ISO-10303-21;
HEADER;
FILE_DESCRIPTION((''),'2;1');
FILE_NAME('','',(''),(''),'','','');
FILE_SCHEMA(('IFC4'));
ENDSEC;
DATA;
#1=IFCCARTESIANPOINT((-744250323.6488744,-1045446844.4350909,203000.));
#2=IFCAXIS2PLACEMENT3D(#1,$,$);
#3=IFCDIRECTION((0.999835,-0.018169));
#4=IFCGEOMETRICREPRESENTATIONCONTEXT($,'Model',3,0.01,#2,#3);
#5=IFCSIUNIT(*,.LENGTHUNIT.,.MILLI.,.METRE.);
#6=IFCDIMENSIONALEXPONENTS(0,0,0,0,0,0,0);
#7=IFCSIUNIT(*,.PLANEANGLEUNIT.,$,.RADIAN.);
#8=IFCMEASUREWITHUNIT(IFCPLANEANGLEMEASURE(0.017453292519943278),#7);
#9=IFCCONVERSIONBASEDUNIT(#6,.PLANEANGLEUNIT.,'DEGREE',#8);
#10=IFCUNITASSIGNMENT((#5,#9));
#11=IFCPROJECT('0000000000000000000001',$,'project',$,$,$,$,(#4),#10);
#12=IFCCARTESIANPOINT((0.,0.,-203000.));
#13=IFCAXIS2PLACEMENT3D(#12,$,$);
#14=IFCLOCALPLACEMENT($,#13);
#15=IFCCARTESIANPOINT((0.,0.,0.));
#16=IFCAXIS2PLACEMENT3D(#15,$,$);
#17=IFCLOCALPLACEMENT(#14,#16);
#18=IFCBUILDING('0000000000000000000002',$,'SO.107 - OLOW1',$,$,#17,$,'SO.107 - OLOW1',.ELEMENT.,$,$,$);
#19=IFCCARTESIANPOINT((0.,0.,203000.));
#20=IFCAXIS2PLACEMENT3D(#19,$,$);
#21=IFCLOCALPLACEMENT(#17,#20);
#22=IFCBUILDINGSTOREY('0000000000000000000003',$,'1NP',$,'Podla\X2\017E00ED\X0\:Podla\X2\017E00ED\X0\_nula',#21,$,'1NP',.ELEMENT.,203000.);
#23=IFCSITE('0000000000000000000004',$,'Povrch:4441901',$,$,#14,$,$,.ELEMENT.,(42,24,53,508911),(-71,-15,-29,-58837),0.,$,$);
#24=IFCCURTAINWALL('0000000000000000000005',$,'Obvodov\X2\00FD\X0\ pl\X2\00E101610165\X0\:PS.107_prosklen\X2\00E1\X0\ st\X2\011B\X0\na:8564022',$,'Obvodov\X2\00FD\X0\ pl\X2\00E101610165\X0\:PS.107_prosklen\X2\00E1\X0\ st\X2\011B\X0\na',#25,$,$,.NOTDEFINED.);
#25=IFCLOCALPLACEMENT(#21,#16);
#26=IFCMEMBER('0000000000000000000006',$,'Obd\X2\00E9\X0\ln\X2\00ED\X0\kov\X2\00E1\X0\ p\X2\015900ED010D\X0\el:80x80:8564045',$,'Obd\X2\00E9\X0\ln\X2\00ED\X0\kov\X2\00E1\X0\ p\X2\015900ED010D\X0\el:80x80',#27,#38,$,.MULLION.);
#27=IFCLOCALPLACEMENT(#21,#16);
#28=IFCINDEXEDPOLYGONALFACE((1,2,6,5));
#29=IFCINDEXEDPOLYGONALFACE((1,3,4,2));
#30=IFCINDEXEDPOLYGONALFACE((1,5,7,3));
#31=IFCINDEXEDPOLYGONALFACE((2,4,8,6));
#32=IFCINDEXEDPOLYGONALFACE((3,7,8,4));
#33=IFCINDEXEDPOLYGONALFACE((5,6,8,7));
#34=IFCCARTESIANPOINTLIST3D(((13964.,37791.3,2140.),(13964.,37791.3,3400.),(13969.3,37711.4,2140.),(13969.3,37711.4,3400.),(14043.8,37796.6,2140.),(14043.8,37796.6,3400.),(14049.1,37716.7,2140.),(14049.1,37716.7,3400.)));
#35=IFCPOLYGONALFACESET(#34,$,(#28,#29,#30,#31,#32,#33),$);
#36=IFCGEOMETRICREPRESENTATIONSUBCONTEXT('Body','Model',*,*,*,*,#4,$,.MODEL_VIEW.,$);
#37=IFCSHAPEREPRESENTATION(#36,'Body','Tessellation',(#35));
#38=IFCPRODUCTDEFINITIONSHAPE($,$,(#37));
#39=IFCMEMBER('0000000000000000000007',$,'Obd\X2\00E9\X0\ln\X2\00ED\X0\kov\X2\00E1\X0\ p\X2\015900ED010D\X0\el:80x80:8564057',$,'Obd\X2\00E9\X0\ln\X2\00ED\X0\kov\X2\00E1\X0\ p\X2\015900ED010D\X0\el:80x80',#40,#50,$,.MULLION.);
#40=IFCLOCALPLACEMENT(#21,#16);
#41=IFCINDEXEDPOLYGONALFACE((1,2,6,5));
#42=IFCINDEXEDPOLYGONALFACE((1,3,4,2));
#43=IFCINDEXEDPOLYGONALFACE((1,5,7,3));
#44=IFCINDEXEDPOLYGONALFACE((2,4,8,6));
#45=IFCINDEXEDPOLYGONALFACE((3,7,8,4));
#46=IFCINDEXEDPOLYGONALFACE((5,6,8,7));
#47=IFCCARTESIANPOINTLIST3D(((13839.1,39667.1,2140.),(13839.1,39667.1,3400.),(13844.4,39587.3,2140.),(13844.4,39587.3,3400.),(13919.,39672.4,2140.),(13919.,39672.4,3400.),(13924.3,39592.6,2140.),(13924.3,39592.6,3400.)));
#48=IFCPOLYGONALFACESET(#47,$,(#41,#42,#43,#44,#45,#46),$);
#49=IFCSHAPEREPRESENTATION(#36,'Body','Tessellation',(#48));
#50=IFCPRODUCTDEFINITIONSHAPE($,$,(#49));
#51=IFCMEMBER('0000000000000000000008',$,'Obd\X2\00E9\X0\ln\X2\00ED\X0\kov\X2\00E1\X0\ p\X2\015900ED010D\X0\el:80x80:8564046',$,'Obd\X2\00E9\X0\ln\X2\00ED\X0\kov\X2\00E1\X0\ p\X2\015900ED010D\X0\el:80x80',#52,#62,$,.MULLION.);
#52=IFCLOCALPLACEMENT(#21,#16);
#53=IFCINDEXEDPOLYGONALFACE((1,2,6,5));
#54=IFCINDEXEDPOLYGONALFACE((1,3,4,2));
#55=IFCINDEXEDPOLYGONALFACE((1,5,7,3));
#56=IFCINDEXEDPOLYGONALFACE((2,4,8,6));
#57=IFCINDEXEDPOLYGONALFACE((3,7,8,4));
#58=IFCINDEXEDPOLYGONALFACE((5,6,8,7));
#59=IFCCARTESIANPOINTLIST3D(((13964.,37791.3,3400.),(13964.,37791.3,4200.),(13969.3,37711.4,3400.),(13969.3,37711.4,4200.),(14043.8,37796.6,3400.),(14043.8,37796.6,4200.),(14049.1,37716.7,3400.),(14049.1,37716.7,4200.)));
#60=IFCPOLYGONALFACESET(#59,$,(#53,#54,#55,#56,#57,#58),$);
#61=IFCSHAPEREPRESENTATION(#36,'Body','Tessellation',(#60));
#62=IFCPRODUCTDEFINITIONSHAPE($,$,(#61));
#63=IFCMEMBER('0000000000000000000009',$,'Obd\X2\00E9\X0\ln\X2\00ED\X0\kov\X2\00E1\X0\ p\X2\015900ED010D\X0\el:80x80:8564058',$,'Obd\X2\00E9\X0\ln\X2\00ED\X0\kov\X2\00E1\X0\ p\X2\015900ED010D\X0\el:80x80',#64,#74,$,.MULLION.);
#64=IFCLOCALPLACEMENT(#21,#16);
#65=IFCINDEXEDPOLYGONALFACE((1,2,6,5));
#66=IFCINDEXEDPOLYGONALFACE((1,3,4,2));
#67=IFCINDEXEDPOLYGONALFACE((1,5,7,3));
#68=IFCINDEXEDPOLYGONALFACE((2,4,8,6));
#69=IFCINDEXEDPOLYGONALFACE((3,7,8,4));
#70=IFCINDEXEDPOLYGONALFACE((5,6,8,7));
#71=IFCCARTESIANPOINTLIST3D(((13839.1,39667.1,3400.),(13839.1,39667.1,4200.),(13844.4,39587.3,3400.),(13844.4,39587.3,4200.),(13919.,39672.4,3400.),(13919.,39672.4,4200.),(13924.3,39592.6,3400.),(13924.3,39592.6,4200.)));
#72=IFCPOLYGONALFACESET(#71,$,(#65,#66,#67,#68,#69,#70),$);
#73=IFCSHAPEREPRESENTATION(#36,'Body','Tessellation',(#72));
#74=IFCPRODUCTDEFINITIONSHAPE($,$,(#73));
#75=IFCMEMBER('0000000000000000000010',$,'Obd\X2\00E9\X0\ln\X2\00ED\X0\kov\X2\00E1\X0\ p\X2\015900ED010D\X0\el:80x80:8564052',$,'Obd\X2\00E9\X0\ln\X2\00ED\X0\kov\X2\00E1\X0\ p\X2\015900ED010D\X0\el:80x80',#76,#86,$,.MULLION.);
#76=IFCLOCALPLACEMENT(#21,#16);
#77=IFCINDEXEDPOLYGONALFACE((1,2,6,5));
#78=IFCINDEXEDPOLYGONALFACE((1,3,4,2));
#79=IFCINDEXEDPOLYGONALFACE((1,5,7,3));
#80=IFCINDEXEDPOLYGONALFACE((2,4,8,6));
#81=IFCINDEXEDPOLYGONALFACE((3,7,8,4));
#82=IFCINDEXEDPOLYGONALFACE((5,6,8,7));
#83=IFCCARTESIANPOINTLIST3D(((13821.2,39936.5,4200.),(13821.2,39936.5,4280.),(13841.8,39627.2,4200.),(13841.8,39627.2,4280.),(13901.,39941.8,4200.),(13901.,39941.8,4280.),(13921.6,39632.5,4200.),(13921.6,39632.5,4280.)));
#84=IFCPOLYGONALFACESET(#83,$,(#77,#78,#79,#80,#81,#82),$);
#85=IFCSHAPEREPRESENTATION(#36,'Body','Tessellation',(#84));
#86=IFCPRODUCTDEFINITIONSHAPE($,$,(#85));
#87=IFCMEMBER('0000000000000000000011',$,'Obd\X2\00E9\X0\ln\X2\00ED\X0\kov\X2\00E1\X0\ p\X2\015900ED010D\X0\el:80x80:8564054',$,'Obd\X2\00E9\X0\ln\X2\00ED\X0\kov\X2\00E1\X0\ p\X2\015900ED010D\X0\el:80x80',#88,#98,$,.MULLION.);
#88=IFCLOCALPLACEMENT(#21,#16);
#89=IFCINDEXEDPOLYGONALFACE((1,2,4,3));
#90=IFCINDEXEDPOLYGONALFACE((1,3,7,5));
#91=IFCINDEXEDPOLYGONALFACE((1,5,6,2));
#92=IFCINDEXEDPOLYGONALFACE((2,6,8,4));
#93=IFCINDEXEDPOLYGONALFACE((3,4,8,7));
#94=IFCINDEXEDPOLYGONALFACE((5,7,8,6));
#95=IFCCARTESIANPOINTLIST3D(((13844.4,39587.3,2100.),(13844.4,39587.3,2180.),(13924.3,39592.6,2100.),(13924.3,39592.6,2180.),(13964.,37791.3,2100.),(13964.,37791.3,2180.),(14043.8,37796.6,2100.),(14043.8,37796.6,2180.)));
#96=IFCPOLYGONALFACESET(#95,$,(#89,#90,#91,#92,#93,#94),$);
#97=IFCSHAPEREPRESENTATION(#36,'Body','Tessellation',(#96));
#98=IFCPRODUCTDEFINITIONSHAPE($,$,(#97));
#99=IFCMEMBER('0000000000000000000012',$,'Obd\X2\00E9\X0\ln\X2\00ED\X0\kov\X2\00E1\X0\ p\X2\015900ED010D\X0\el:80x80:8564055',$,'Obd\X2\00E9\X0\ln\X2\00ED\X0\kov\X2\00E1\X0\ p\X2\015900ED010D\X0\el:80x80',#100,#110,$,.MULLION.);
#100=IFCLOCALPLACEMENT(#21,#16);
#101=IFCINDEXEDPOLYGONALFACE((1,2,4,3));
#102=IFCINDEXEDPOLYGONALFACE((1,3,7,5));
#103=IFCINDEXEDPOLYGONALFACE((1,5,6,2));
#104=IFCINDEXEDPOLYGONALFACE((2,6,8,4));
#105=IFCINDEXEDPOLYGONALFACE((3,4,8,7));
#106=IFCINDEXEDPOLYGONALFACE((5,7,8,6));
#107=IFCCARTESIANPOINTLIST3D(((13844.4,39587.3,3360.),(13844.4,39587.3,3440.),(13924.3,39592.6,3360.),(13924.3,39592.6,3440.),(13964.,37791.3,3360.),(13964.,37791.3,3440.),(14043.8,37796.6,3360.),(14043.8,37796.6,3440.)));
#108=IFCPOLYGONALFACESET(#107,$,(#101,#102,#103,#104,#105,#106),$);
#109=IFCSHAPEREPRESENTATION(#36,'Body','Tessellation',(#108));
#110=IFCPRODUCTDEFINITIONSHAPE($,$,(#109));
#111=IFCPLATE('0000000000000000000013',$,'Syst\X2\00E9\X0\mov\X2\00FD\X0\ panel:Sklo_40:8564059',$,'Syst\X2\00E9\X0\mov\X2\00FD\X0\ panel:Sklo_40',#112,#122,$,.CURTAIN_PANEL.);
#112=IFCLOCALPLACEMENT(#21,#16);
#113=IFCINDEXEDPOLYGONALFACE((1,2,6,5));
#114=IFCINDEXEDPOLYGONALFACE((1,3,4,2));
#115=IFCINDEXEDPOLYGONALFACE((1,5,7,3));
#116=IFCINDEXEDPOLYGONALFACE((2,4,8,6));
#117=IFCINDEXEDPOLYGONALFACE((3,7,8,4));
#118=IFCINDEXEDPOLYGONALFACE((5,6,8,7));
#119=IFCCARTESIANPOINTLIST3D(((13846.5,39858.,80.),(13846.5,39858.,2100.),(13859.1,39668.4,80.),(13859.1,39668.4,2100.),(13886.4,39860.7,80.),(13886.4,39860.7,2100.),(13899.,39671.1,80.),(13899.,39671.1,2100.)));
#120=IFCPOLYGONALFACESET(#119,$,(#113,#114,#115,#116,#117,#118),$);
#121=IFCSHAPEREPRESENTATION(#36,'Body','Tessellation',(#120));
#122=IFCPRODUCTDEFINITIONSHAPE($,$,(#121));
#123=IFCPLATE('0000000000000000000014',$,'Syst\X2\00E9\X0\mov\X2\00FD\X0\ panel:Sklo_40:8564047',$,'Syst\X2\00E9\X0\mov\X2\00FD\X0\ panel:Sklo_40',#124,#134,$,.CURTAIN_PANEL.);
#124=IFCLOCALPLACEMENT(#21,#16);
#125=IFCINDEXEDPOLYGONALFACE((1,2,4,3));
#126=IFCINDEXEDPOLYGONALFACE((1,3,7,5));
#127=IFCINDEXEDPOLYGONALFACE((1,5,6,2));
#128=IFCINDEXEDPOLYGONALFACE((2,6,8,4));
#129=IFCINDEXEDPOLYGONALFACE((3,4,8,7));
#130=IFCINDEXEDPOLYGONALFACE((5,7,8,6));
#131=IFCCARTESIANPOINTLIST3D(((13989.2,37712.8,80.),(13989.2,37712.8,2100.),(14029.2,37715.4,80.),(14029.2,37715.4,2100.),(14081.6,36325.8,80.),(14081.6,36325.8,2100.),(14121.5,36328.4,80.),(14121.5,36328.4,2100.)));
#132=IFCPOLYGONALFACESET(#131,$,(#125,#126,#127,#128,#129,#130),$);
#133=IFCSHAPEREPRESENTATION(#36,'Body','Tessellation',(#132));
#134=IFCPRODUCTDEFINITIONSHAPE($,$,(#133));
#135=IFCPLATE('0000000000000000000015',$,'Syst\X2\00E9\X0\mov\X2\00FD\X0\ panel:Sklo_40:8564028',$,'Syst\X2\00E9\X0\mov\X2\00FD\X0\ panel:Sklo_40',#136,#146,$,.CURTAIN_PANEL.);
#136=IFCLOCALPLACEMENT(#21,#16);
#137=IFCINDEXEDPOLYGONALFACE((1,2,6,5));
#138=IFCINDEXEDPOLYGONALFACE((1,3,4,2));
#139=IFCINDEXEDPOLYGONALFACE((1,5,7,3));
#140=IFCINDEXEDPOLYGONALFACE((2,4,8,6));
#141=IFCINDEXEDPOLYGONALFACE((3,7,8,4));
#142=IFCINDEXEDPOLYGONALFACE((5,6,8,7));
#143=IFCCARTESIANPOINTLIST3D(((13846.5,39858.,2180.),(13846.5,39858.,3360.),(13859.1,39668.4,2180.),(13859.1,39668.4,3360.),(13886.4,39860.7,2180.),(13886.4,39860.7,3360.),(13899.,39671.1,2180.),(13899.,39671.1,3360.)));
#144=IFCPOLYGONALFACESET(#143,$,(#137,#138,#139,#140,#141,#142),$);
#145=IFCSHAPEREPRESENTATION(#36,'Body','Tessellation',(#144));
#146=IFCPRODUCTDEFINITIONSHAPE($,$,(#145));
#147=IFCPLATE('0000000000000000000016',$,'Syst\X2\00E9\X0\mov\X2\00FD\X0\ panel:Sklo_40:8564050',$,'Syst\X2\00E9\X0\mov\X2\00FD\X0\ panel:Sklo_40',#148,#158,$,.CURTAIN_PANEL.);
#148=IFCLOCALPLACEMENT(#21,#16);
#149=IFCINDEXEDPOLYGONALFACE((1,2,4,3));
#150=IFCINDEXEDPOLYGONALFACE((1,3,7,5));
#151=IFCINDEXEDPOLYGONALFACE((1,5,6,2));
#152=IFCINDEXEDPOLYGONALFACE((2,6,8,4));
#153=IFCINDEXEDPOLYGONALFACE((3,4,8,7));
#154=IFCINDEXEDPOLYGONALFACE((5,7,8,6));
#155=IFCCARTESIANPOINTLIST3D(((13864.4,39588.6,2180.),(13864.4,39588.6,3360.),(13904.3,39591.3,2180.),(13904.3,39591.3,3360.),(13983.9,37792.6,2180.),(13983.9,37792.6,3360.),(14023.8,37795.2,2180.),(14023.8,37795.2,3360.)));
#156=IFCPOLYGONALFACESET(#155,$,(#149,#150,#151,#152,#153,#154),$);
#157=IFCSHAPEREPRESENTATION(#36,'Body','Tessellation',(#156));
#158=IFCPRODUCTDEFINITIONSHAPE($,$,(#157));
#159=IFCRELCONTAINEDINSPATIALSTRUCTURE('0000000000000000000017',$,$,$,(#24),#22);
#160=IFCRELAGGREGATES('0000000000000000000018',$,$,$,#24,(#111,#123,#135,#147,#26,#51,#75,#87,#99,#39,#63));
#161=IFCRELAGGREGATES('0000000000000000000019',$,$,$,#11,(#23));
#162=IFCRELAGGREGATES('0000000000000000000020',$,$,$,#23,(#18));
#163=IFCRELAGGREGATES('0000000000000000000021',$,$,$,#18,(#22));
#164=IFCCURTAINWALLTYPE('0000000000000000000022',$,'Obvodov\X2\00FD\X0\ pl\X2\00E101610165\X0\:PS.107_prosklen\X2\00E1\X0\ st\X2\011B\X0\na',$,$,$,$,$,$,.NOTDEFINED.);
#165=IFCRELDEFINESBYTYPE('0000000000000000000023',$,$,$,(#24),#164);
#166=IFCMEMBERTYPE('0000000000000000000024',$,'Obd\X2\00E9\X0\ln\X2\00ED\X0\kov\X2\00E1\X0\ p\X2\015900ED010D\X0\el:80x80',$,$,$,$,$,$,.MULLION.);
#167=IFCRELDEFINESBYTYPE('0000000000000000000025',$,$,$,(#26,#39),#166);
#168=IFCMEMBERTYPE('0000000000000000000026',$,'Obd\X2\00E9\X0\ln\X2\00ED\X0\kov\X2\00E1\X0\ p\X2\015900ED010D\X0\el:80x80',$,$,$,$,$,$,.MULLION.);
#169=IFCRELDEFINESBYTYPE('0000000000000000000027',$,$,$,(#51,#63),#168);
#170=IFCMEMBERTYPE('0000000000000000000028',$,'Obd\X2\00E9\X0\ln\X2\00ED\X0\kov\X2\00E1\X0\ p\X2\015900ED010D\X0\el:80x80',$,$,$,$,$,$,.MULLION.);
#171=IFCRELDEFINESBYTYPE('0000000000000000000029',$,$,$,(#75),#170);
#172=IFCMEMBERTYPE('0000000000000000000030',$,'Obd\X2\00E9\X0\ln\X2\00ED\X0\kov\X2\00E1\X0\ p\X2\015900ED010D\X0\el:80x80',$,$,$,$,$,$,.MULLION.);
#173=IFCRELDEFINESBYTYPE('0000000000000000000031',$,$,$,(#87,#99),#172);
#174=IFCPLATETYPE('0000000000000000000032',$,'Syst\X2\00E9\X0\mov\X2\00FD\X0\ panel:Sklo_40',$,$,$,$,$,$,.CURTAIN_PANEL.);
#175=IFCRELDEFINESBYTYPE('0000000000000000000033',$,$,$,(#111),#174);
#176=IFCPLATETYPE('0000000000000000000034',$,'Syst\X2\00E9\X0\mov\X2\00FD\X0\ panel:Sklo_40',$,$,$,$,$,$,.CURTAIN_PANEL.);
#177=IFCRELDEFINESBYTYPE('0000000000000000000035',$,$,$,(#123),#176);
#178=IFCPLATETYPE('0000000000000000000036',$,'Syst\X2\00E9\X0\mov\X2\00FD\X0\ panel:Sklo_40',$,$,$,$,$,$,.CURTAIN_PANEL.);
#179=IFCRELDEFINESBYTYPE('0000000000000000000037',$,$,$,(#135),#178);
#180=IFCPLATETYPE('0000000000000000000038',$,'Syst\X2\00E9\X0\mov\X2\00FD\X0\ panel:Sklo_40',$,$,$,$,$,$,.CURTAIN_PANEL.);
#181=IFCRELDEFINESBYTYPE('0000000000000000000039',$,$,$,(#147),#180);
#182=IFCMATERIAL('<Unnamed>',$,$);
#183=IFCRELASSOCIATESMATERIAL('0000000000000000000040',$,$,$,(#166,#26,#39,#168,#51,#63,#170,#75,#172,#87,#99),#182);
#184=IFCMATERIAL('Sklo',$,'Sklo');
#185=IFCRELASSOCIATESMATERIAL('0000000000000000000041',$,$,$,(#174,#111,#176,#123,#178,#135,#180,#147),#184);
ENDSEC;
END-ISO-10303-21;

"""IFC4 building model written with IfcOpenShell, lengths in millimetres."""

from ifc_helpers import new_model, entity, si_unit, converted_unit, direction, frame, origin, place, context, subcontext, project, spatial, indexed_curve, outline, extrude, source, transform, mapped, material, type_object, type_shapes, element, aggregate, save


model = new_model("IFC4")

# Units and contexts
model_context = context("Model", 3, precision=0.01, world=frame((-744250323.6488744, -1045446844.4350909, 203000.0)), true_north=direction((0.999835, -0.018169)))
body_context = subcontext(model_context, "Body", "Model", "MODEL_VIEW")
ifc_project = project(units=[si_unit("LENGTHUNIT", "METRE", prefix="MILLI"), converted_unit("PLANEANGLEUNIT", "DEGREE", entity("IfcPlaneAngleMeasure", 0.017453292519943278), si_unit("PLANEANGLEUNIT", "RADIAN"), dimensions=[0, 0, 0, 0, 0, 0, 0])], contexts=[model_context])

# Site, building, storey
site_placement = place(None, frame((0.0, 0.0, -203000.0)))
site = spatial("IfcSite", under=ifc_project, at=site_placement, Name="Povrch:4441901", CompositionType="ELEMENT", RefLatitude=(42, 24, 53, 508911), RefLongitude=(-71, -15, -29, -58837), RefElevation=0.0)
building_placement = place(site_placement, origin())
building = spatial("IfcBuilding", under=site, at=building_placement, Name="SO.107 - OLOW1", LongName="SO.107 - OLOW1", CompositionType="ELEMENT")
storey_placement = place(building_placement, frame((0.0, 0.0, 203000.0)))
storey = spatial("IfcBuildingStorey", under=building, at=storey_placement, Name="1NP", ObjectType="Podlaží:Podlaží_nula", LongName="1NP", CompositionType="ELEMENT", Elevation=203000.0)

# Curtain wall, members, plates
curtain_wall_type = type_object("IfcCurtainWallType", Name="Obvodový plášť:PS.107_prosklená stěna", PredefinedType="NOTDEFINED")
curtain_wall_placement = place(storey_placement, frame((0.0, 0.0, -203000.0)))
curtain_wall = element("IfcCurtainWall", 1, at=curtain_wall_placement, inside=storey, type_object=curtain_wall_type, Name="Obvodový plášť:PS.107_prosklená stěna:8564022", ObjectType="Obvodový plášť:PS.107_prosklená stěna", PredefinedType="NOTDEFINED")
ifc_material_1 = material(Name="<Unnamed>")
member_type_1 = type_object("IfcMemberType", Name="Obdélníková příčel:80x80", PredefinedType="MULLION", material=ifc_material_1)
shared_shape_1 = source(origin(), body_context, "Body", "SweptSolid", [
    extrude(outline(indexed_curve([(-40.0, -40.0), (40.0, -40.0), (40.0, 40.0), (-40.0, 40.0), (-40.0, -40.0)], self_intersect=False)), frame((0.0, 0.0, -1260.0), z_axis=(0.0, 0.0, 1.0), x_axis=(-1.0, 0.0, 0.0)), (0.0, 0.0, 1.0), 1260.0),
])
type_shapes(member_type_1, [shared_shape_1])
member_1_placement = place(curtain_wall_placement, frame((14006.5, 37754.0, 205140.0), z_axis=(0.0, 0.0, -1.0), x_axis=(0.066409, -0.997792, 0.0)))
member_1 = element("IfcMember", 2, at=member_1_placement, type_object=member_type_1, material=ifc_material_1, Name="Obdélníková příčel:80x80:8564045", ObjectType="Obdélníková příčel:80x80", PredefinedType="MULLION", context=body_context, shape_type="MappedRepresentation", body=[
    mapped(shared_shape_1, transform((0.0, 0.0, 0.0), scale=1.0)),
])
member_2_placement = place(curtain_wall_placement, frame((13881.7, 39629.8, 205140.0), z_axis=(0.0, 0.0, -1.0), x_axis=(0.066409, -0.997792, 0.0)))
member_2 = element("IfcMember", 3, at=member_2_placement, type_object=member_type_1, material=ifc_material_1, Name="Obdélníková příčel:80x80:8564057", ObjectType="Obdélníková příčel:80x80", PredefinedType="MULLION", context=body_context, shape_type="MappedRepresentation", body=[
    mapped(shared_shape_1, transform((0.0, 0.0, 0.0), scale=1.0)),
])
member_type_2 = type_object("IfcMemberType", Name="Obdélníková příčel:80x80", PredefinedType="MULLION", material=ifc_material_1)
shared_shape_2 = source(origin(), body_context, "Body", "SweptSolid", [
    extrude(outline(indexed_curve([(-40.0, -40.0), (40.0, -40.0), (40.0, 40.0), (-40.0, 40.0), (-40.0, -40.0)], self_intersect=False)), frame((0.0, 0.0, -800.0), z_axis=(0.0, 0.0, 1.0), x_axis=(-1.0, 0.0, 0.0)), (0.0, 0.0, 1.0), 800.0),
])
type_shapes(member_type_2, [shared_shape_2])
member_3_placement = place(curtain_wall_placement, frame((14006.5, 37754.0, 206400.0), z_axis=(0.0, 0.0, -1.0), x_axis=(0.066409, -0.997792, 0.0)))
member_3 = element("IfcMember", 4, at=member_3_placement, type_object=member_type_2, material=ifc_material_1, Name="Obdélníková příčel:80x80:8564046", ObjectType="Obdélníková příčel:80x80", PredefinedType="MULLION", context=body_context, shape_type="MappedRepresentation", body=[
    mapped(shared_shape_2, transform((0.0, 0.0, 0.0), scale=1.0)),
])
member_4_placement = place(curtain_wall_placement, frame((13881.7, 39629.8, 206400.0), z_axis=(0.0, 0.0, -1.0), x_axis=(0.066409, -0.997792, 0.0)))
member_4 = element("IfcMember", 5, at=member_4_placement, type_object=member_type_2, material=ifc_material_1, Name="Obdélníková příčel:80x80:8564058", ObjectType="Obdélníková příčel:80x80", PredefinedType="MULLION", context=body_context, shape_type="MappedRepresentation", body=[
    mapped(shared_shape_2, transform((0.0, 0.0, 0.0), scale=1.0)),
])
member_type_3 = type_object("IfcMemberType", Name="Obdélníková příčel:80x80", PredefinedType="MULLION", material=ifc_material_1)
shared_shape_3 = source(origin(), body_context, "Body", "SweptSolid", [
    extrude(outline(indexed_curve([(-40.0, -40.0), (40.0, -40.0), (40.0, 40.0), (-40.0, 40.0), (-40.0, -40.0)], self_intersect=False)), frame((-40.0, 0.0, -310.0), z_axis=(0.0, 0.0, 1.0), x_axis=(-1.0, 0.0, 0.0)), (0.0, 0.0, 1.0), 310.0),
])
type_shapes(member_type_3, [shared_shape_3])
member_5_placement = place(curtain_wall_placement, frame((13881.7, 39629.8, 207280.0), z_axis=(0.066409, -0.997792, 0.0), x_axis=(0.0, 0.0, 1.0)))
member_5 = element("IfcMember", 6, at=member_5_placement, type_object=member_type_3, material=ifc_material_1, Name="Obdélníková příčel:80x80:8564052", ObjectType="Obdélníková příčel:80x80", PredefinedType="MULLION", context=body_context, shape_type="MappedRepresentation", body=[
    mapped(shared_shape_3, transform((0.0, 0.0, 0.0), scale=1.0)),
])
member_type_4 = type_object("IfcMemberType", Name="Obdélníková příčel:80x80", PredefinedType="MULLION", material=ifc_material_1)
shared_shape_4 = source(origin(), body_context, "Body", "SweptSolid", [
    extrude(outline(indexed_curve([(-40.0, -40.0), (40.0, -40.0), (40.0, 40.0), (-40.0, 40.0), (-40.0, -40.0)], self_intersect=False)), frame((0.0, 0.0, -1800.0), z_axis=(0.0, 0.0, 1.0), x_axis=(-1.0, 0.0, 0.0)), (0.0, 0.0, 1.0), 1800.0),
])
type_shapes(member_type_4, [shared_shape_4])
member_6_placement = place(curtain_wall_placement, frame((14003.9, 37793.9, 205140.0), z_axis=(0.066409, -0.997792, 0.0), x_axis=(0.0, 0.0, 1.0)))
member_6 = element("IfcMember", 7, at=member_6_placement, type_object=member_type_4, material=ifc_material_1, Name="Obdélníková příčel:80x80:8564054", ObjectType="Obdélníková příčel:80x80", PredefinedType="MULLION", context=body_context, shape_type="MappedRepresentation", body=[
    mapped(shared_shape_4, transform((0.0, 0.0, 0.0), scale=1.0)),
])
member_7_placement = place(curtain_wall_placement, frame((14003.9, 37793.9, 206400.0), z_axis=(0.066409, -0.997792, 0.0), x_axis=(0.0, 0.0, 1.0)))
member_7 = element("IfcMember", 8, at=member_7_placement, type_object=member_type_4, material=ifc_material_1, Name="Obdélníková příčel:80x80:8564055", ObjectType="Obdélníková příčel:80x80", PredefinedType="MULLION", context=body_context, shape_type="MappedRepresentation", body=[
    mapped(shared_shape_4, transform((0.0, 0.0, 0.0), scale=1.0)),
])
ifc_material_2 = material(Name="Sklo", Category="Sklo")
plate_type_1 = type_object("IfcPlateType", Name="Systémový panel:Sklo_40", PredefinedType="CURTAIN_PANEL", material=ifc_material_2)
shared_shape_5 = source(origin(), body_context, "Body", "SweptSolid", [
    extrude(outline(indexed_curve([(-20.0, -95.0), (20.0, -95.0), (20.0, 95.0), (-20.0, 95.0), (-20.0, -95.0)], self_intersect=False)), frame((0.0, 0.0, 0.0), z_axis=(0.0, 0.0, 1.0), x_axis=(0.0, 1.0, 0.0)), (0.0, 0.0, 1.0), 2020.0),
])
type_shapes(plate_type_1, [shared_shape_5])
plate_1_placement = place(curtain_wall_placement, frame((13872.7, 39764.5, 203080.0), z_axis=(0.0, 0.0, 1.0), x_axis=(0.066409, -0.997792, 0.0)))
plate_1 = element("IfcPlate", 9, at=plate_1_placement, type_object=plate_type_1, material=ifc_material_2, Name="Systémový panel:Sklo_40:8564059", ObjectType="Systémový panel:Sklo_40", PredefinedType="CURTAIN_PANEL", context=body_context, shape_type="MappedRepresentation", body=[
    mapped(shared_shape_5, transform((0.0, 0.0, 0.0), scale=1.0)),
])
plate_type_2 = type_object("IfcPlateType", Name="Systémový panel:Sklo_40", PredefinedType="CURTAIN_PANEL", material=ifc_material_2)
shared_shape_6 = source(origin(), body_context, "Body", "SweptSolid", [
    extrude(outline(indexed_curve([(-20.0, -695.0), (20.0, -695.0), (20.0, 695.0), (-20.0, 695.0), (-20.0, -695.0)], self_intersect=False)), frame((0.0, 0.0, 0.0), z_axis=(0.0, 0.0, 1.0), x_axis=(0.0, 1.0, 0.0)), (0.0, 0.0, 1.0), 2020.0),
])
type_shapes(plate_type_2, [shared_shape_6])
plate_2_placement = place(curtain_wall_placement, frame((14055.4, 37020.6, 203080.0), z_axis=(0.0, 0.0, 1.0), x_axis=(0.066409, -0.997792, 0.0)))
plate_2 = element("IfcPlate", 10, at=plate_2_placement, type_object=plate_type_2, material=ifc_material_2, Name="Systémový panel:Sklo_40:8564047", ObjectType="Systémový panel:Sklo_40", PredefinedType="CURTAIN_PANEL", context=body_context, shape_type="MappedRepresentation", body=[
    mapped(shared_shape_6, transform((0.0, 0.0, 0.0), scale=1.0)),
])
plate_type_3 = type_object("IfcPlateType", Name="Systémový panel:Sklo_40", PredefinedType="CURTAIN_PANEL", material=ifc_material_2)
shared_shape_7 = source(origin(), body_context, "Body", "SweptSolid", [
    extrude(outline(indexed_curve([(-20.0, -95.0), (20.0, -95.0), (20.0, 95.0), (-20.0, 95.0), (-20.0, -95.0)], self_intersect=False)), frame((0.0, 0.0, 0.0), z_axis=(0.0, 0.0, 1.0), x_axis=(0.0, 1.0, 0.0)), (0.0, 0.0, 1.0), 1180.0),
])
type_shapes(plate_type_3, [shared_shape_7])
plate_3_placement = place(curtain_wall_placement, frame((13872.7, 39764.5, 205180.0), z_axis=(0.0, 0.0, 1.0), x_axis=(0.066409, -0.997792, 0.0)))
plate_3 = element("IfcPlate", 11, at=plate_3_placement, type_object=plate_type_3, material=ifc_material_2, Name="Systémový panel:Sklo_40:8564028", ObjectType="Systémový panel:Sklo_40", PredefinedType="CURTAIN_PANEL", context=body_context, shape_type="MappedRepresentation", body=[
    mapped(shared_shape_7, transform((0.0, 0.0, 0.0), scale=1.0)),
])
plate_type_4 = type_object("IfcPlateType", Name="Systémový panel:Sklo_40", PredefinedType="CURTAIN_PANEL", material=ifc_material_2)
shared_shape_8 = source(origin(), body_context, "Body", "SweptSolid", [
    extrude(outline(indexed_curve([(-20.0, -900.0), (20.0, -900.0), (20.0, 900.0), (-20.0, 900.0), (-20.0, -900.0)], self_intersect=False)), frame((0.0, 0.0, 0.0), z_axis=(0.0, 0.0, 1.0), x_axis=(0.0, 1.0, 0.0)), (0.0, 0.0, 1.0), 1180.0),
])
type_shapes(plate_type_4, [shared_shape_8])
plate_4_placement = place(curtain_wall_placement, frame((13944.1, 38691.9, 205180.0), z_axis=(0.0, 0.0, 1.0), x_axis=(0.066409, -0.997792, 0.0)))
plate_4 = element("IfcPlate", 12, at=plate_4_placement, type_object=plate_type_4, material=ifc_material_2, Name="Systémový panel:Sklo_40:8564050", ObjectType="Systémový panel:Sklo_40", PredefinedType="CURTAIN_PANEL", context=body_context, shape_type="MappedRepresentation", body=[
    mapped(shared_shape_8, transform((0.0, 0.0, 0.0), scale=1.0)),
])
aggregate(curtain_wall, [plate_1, plate_2, plate_3, plate_4, member_1, member_3, member_5, member_6, member_7, member_2, member_4])

save(model, "model.ifc")
